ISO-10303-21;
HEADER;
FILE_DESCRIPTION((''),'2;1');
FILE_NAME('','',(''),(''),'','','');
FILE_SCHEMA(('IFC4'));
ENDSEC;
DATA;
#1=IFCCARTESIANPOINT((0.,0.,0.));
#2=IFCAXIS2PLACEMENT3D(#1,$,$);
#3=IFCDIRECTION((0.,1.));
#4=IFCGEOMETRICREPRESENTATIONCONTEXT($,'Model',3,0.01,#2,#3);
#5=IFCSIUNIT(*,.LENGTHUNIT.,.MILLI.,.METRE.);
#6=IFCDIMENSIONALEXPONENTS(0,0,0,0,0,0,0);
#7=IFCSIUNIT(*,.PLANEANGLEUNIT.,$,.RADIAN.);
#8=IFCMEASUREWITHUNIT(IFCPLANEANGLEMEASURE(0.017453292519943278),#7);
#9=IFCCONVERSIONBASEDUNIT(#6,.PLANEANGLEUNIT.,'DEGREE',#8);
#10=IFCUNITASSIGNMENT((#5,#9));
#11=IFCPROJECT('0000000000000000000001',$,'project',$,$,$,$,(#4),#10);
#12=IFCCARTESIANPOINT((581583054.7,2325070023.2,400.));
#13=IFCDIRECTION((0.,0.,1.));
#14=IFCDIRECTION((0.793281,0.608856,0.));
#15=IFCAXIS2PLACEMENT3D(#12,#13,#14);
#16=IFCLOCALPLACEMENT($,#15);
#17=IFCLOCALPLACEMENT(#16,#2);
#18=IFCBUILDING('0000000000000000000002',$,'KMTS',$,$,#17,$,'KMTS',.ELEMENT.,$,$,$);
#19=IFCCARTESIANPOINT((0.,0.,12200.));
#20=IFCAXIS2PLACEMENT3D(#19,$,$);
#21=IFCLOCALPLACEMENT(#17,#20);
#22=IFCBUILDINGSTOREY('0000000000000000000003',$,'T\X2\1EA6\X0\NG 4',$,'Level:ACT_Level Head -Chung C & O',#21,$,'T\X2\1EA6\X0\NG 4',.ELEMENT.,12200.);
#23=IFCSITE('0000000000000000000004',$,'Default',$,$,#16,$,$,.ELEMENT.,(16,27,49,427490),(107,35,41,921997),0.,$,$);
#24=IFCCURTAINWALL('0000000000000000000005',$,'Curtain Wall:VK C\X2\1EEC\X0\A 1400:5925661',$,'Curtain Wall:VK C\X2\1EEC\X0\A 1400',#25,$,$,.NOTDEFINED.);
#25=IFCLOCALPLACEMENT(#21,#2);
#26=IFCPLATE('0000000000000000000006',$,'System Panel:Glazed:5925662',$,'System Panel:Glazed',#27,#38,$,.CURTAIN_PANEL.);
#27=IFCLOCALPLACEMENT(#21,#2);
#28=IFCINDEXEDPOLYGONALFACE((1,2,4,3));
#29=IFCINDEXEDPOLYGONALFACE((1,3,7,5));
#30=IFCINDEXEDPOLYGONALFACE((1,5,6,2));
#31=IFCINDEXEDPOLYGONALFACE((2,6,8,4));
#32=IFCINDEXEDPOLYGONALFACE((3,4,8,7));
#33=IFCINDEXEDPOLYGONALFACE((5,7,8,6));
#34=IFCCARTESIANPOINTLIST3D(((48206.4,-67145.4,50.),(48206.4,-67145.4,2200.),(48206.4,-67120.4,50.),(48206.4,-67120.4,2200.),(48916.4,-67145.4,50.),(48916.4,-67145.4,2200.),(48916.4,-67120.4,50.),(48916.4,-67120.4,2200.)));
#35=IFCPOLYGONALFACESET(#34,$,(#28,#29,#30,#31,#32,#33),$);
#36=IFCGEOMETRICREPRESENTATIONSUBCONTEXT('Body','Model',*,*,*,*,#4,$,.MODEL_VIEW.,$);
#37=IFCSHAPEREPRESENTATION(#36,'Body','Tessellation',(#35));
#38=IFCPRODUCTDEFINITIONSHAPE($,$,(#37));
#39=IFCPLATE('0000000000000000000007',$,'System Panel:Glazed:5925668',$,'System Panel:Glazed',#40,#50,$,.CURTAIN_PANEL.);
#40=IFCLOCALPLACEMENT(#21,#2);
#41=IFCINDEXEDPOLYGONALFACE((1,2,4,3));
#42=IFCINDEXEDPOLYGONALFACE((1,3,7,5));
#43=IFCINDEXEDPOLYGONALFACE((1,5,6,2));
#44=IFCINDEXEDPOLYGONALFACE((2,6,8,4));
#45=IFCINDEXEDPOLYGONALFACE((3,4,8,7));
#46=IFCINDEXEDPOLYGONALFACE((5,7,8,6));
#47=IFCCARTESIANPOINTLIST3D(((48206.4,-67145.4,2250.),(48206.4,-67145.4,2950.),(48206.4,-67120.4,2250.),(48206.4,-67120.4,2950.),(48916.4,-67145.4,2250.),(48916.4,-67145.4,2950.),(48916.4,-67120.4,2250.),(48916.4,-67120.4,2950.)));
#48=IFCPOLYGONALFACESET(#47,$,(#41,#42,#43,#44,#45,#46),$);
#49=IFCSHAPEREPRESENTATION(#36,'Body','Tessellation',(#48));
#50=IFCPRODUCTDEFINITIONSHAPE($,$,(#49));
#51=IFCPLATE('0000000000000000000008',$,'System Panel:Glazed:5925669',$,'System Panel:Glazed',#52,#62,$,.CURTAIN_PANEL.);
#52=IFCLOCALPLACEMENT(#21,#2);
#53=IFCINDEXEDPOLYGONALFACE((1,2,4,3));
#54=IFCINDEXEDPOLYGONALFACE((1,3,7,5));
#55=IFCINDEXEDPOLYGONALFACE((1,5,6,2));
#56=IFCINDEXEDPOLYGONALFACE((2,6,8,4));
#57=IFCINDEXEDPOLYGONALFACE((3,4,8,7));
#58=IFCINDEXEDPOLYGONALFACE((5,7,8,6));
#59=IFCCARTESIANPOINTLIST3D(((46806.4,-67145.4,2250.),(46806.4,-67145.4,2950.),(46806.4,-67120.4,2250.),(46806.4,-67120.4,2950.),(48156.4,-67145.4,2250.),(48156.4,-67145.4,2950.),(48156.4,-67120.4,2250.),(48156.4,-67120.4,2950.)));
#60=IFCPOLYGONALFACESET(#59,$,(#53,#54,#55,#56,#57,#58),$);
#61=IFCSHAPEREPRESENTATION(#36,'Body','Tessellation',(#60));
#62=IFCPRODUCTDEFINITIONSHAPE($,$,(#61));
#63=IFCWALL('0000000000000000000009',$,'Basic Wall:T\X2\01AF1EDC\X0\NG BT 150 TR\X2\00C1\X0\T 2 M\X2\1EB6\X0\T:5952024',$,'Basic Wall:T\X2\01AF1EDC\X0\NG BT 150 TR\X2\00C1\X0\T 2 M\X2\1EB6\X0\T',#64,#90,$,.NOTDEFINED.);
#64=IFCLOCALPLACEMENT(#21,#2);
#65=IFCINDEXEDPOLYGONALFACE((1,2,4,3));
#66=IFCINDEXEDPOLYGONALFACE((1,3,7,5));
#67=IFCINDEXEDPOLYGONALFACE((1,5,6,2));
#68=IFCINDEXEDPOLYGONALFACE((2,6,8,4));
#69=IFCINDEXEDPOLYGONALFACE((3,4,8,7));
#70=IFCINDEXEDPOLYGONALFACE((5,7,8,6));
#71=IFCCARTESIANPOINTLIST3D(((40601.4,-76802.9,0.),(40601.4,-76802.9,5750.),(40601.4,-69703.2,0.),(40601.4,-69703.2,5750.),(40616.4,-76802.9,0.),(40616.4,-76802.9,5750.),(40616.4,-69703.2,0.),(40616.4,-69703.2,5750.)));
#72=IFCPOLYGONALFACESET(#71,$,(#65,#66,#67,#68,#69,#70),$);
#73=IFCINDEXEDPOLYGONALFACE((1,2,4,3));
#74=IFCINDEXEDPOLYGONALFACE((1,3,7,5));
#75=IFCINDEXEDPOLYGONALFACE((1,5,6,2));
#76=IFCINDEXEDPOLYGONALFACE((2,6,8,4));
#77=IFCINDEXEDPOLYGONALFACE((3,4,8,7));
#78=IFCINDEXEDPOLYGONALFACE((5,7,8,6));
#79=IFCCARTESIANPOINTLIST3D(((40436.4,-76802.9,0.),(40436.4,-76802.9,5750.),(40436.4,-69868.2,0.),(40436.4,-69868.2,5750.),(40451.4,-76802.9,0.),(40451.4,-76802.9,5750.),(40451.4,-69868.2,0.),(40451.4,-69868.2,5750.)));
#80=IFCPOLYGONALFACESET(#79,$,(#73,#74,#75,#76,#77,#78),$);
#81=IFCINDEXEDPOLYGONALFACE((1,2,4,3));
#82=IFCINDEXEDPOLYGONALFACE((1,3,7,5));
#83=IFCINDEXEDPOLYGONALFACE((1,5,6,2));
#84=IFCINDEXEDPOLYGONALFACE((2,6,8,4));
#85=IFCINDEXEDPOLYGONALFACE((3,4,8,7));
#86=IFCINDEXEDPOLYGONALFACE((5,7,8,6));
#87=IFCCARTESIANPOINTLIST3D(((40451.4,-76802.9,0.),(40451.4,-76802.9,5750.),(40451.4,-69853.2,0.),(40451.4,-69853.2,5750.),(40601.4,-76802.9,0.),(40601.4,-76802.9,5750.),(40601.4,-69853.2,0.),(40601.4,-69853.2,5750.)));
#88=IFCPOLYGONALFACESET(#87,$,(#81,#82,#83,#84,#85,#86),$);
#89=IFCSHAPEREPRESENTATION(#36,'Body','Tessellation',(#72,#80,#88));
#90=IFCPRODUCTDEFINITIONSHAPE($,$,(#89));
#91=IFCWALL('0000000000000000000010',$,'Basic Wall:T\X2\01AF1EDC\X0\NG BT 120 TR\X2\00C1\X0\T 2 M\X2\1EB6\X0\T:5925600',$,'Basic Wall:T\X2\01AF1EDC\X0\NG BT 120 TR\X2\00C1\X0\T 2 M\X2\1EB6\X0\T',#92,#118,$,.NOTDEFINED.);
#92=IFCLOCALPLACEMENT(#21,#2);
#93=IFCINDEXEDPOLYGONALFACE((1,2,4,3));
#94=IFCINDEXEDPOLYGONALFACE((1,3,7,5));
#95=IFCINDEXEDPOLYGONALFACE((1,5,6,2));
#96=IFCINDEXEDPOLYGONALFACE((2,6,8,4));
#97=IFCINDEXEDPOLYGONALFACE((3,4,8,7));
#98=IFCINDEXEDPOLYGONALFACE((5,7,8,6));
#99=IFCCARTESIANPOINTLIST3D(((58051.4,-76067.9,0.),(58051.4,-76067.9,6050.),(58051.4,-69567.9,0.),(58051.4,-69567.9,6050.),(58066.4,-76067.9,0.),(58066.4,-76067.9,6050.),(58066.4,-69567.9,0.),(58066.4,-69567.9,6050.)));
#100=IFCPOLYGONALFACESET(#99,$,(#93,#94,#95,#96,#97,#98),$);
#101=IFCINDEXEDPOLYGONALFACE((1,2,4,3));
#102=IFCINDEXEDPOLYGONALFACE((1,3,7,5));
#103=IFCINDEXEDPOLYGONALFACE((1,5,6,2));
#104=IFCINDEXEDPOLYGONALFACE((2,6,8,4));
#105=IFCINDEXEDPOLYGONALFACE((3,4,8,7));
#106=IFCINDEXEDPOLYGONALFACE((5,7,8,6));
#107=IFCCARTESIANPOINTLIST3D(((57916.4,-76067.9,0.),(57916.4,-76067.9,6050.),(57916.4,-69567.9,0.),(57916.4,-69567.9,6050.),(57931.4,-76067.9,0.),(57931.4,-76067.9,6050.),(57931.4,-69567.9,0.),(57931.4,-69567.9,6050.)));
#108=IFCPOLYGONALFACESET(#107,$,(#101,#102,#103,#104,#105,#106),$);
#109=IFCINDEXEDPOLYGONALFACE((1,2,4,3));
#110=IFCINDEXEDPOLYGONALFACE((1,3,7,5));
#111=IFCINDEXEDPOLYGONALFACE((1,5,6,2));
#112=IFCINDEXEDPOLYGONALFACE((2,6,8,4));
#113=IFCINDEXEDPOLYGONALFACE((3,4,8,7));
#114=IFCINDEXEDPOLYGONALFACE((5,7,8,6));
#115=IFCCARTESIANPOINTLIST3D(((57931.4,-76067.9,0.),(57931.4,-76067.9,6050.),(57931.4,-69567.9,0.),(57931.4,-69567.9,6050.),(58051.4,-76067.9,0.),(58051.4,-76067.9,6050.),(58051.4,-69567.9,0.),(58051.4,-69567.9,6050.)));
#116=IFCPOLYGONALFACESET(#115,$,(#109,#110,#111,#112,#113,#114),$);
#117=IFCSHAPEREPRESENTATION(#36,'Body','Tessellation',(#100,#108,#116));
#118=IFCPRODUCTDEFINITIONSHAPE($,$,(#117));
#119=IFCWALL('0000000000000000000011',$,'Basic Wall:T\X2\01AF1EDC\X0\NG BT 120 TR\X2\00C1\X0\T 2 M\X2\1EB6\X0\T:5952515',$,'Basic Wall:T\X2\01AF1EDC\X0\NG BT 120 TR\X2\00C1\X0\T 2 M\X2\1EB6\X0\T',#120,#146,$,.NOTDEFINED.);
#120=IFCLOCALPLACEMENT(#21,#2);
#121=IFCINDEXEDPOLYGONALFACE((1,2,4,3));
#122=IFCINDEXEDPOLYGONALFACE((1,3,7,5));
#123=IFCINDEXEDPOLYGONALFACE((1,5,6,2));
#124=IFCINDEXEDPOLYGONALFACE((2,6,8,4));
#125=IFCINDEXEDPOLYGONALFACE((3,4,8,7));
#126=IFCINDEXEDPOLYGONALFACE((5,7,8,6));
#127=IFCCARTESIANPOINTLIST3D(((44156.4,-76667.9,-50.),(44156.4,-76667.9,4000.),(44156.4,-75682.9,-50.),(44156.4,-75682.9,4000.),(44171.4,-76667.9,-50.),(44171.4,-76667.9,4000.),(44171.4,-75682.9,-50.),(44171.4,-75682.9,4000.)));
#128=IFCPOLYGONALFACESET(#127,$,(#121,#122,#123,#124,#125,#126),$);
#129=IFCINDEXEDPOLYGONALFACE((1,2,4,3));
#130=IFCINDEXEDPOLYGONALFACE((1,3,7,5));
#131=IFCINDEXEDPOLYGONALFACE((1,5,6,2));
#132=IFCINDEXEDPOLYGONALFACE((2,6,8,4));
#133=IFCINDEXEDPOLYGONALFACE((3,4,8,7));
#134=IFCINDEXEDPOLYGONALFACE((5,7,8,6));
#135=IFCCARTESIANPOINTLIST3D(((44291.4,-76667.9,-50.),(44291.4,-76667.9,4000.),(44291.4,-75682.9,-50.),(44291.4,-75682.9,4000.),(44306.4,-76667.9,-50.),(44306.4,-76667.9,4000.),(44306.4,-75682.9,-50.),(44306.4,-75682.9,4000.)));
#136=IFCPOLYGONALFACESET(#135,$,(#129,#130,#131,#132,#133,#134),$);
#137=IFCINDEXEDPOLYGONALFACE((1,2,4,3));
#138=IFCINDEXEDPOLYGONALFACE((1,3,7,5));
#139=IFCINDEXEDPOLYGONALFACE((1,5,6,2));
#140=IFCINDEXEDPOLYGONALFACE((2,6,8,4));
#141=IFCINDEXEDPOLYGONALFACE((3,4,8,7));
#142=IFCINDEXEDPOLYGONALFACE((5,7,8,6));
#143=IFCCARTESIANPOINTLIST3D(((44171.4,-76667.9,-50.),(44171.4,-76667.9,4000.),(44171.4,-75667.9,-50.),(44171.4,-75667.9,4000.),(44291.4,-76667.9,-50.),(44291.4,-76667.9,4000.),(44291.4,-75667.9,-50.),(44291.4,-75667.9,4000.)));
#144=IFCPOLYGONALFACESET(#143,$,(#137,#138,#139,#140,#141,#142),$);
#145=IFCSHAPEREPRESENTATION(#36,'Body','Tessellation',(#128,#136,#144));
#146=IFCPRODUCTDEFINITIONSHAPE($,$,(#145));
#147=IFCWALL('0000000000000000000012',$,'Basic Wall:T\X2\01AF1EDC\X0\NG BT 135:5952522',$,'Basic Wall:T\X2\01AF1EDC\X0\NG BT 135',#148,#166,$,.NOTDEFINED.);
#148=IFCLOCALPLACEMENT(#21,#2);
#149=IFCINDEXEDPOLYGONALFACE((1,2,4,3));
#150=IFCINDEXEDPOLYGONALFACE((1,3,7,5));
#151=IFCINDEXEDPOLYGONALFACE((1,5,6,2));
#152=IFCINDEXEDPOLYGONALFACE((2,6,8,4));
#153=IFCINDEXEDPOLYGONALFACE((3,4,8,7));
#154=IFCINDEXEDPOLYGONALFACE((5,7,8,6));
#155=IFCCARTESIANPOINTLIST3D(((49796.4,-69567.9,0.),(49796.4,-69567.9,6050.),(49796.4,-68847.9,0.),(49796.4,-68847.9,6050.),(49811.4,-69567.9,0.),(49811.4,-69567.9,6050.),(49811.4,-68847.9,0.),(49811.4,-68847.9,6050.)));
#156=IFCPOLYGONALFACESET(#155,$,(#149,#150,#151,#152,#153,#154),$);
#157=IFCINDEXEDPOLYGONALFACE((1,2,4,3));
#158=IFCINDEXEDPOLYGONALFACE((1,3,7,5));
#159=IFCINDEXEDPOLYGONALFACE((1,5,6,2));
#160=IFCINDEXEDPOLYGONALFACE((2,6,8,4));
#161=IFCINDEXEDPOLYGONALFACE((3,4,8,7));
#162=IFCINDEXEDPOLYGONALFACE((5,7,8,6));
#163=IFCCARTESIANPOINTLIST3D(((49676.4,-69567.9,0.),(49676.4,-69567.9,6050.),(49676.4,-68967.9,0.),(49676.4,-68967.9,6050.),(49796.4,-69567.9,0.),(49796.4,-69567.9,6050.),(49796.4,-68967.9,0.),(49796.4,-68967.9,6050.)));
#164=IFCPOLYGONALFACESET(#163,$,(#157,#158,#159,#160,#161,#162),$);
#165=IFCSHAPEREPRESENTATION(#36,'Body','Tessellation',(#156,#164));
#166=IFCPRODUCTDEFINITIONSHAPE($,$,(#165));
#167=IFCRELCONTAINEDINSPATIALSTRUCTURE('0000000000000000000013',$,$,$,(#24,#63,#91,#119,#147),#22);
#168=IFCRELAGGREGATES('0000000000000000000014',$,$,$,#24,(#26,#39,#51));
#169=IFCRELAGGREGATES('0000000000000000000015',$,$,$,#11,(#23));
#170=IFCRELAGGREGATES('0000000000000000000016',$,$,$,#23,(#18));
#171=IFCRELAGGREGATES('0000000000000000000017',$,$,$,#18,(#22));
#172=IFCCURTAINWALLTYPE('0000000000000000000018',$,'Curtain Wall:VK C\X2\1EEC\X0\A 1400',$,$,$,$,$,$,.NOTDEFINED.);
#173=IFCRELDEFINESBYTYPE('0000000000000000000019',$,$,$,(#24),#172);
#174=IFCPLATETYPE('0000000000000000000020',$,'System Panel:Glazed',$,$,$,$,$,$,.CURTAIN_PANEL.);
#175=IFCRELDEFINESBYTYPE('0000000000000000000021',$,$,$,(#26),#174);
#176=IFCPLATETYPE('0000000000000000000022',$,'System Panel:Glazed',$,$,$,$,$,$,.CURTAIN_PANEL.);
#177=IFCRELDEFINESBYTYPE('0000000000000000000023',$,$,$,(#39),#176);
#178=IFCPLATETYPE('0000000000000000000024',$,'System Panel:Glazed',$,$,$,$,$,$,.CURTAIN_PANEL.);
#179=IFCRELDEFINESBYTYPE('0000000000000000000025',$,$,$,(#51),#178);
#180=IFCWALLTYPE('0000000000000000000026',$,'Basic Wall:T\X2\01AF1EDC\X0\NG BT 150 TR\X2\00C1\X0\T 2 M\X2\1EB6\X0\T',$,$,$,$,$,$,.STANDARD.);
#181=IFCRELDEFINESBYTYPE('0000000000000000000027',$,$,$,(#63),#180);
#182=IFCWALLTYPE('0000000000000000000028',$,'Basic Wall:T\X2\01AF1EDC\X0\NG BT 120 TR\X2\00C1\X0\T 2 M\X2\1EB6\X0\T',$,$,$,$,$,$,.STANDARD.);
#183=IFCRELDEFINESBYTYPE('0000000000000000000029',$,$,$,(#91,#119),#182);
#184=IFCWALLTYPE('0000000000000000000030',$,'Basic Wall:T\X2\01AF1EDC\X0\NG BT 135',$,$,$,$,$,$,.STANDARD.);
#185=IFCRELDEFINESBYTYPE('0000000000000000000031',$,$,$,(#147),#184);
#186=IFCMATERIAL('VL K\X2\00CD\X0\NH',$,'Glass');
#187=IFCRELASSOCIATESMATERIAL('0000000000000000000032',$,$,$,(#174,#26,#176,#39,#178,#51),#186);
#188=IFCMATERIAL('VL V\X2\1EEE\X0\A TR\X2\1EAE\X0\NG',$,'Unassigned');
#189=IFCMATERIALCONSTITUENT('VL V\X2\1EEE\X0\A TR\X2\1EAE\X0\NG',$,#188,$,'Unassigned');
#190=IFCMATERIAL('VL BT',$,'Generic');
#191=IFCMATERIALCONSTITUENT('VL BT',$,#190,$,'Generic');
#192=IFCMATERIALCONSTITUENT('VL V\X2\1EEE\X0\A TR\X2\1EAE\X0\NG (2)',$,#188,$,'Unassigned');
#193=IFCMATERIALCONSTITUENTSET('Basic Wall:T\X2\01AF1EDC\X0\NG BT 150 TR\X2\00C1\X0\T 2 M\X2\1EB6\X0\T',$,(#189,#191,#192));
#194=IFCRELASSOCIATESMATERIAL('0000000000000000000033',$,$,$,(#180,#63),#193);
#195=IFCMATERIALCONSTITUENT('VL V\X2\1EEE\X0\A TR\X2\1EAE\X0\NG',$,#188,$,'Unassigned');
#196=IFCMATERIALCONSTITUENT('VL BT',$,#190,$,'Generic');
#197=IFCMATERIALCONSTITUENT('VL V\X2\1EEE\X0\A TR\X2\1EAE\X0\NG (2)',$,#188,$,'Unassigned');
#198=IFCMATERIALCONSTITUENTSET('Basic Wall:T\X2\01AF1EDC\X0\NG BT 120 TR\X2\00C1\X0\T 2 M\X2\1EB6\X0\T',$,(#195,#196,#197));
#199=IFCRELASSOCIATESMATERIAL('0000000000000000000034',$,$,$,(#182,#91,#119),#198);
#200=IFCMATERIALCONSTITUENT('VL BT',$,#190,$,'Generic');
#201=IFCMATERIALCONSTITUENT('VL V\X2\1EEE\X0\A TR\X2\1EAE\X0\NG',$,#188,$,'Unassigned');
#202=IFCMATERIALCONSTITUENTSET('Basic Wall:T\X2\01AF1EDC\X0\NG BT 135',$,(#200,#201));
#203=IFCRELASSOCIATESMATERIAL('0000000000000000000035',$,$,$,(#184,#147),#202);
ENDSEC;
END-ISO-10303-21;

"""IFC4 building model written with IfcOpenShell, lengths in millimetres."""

from ifc_helpers import new_model, entity, si_unit, converted_unit, direction, frame, origin, place, context, subcontext, project, spatial, indexed_curve, outline, extrude, source, transform, mapped, material, constituent, constituent_set, type_object, type_shapes, element, aggregate, save


model = new_model("IFC4")

# Units and contexts
model_context = context("Model", 3, precision=0.01, world=origin(), true_north=direction((0.0, 1.0)))
body_context = subcontext(model_context, "Body", "Model", "MODEL_VIEW")
ifc_project = project(units=[si_unit("LENGTHUNIT", "METRE", prefix="MILLI"), converted_unit("PLANEANGLEUNIT", "DEGREE", entity("IfcPlaneAngleMeasure", 0.017453292519943278), si_unit("PLANEANGLEUNIT", "RADIAN"), dimensions=[0, 0, 0, 0, 0, 0, 0])], contexts=[model_context])

# Site, building, storey
site_placement = place(None, frame((581583054.7, 2325070023.2, 400.0), z_axis=(0.0, 0.0, 1.0), x_axis=(0.793281, 0.608856, 0.0)))
site = spatial("IfcSite", under=ifc_project, at=site_placement, Name="Default", CompositionType="ELEMENT", RefLatitude=(16, 27, 49, 427490), RefLongitude=(107, 35, 41, 921997), RefElevation=0.0)
building_placement = place(site_placement, origin())
building = spatial("IfcBuilding", under=site, at=building_placement, Name="KMTS", LongName="KMTS", CompositionType="ELEMENT")
storey_placement = place(building_placement, frame((0.0, 0.0, 12200.0)))
storey = spatial("IfcBuildingStorey", under=building, at=storey_placement, Name="TẦNG 4", ObjectType="Level:ACT_Level Head -Chung C & O", LongName="TẦNG 4", CompositionType="ELEMENT", Elevation=12200.0)

# Curtain wall, plates
curtain_wall_type = type_object("IfcCurtainWallType", Name="Curtain Wall:VK CỬA 1400", PredefinedType="NOTDEFINED")
curtain_wall_placement = place(storey_placement, frame((0.0, 0.0, -12200.0)))
curtain_wall = element("IfcCurtainWall", 1, at=curtain_wall_placement, inside=storey, type_object=curtain_wall_type, Name="Curtain Wall:VK CỬA 1400:5925661", ObjectType="Curtain Wall:VK CỬA 1400", PredefinedType="NOTDEFINED")
ifc_material_1 = material(Name="VL KÍNH", Category="Glass")
plate_type_1 = type_object("IfcPlateType", Name="System Panel:Glazed", PredefinedType="CURTAIN_PANEL", material=ifc_material_1)
shared_shape_1 = source(origin(), body_context, "Body", "SweptSolid", [
    extrude(outline(indexed_curve([(-12.5, -355.0), (12.5, -355.0), (12.5, 355.0), (-12.5, 355.0), (-12.5, -355.0)], self_intersect=False)), frame((0.0, 0.0, 0.0), z_axis=(0.0, 0.0, 1.0), x_axis=(0.0, 1.0, 0.0)), (0.0, 0.0, 1.0), 2150.0),
])
type_shapes(plate_type_1, [shared_shape_1])
plate_1_placement = place(curtain_wall_placement, frame((48561.4, -67132.9, 12250.0), z_axis=(0.0, 0.0, 1.0), x_axis=(-1.0, 0.0, 0.0)))
plate_1 = element("IfcPlate", 2, at=plate_1_placement, type_object=plate_type_1, material=ifc_material_1, Name="System Panel:Glazed:5925662", ObjectType="System Panel:Glazed", PredefinedType="CURTAIN_PANEL", context=body_context, shape_type="MappedRepresentation", body=[
    mapped(shared_shape_1, transform((0.0, 0.0, 0.0), scale=1.0)),
])
plate_type_2 = type_object("IfcPlateType", Name="System Panel:Glazed", PredefinedType="CURTAIN_PANEL", material=ifc_material_1)
shared_shape_2 = source(origin(), body_context, "Body", "SweptSolid", [
    extrude(outline(indexed_curve([(-12.5, -355.0), (12.5, -355.0), (12.5, 355.0), (-12.5, 355.0), (-12.5, -355.0)], self_intersect=False)), frame((0.0, 0.0, 0.0), z_axis=(0.0, 0.0, 1.0), x_axis=(0.0, 1.0, 0.0)), (0.0, 0.0, 1.0), 700.0),
])
type_shapes(plate_type_2, [shared_shape_2])
plate_2_placement = place(curtain_wall_placement, frame((48561.4, -67132.9, 14450.0), z_axis=(0.0, 0.0, 1.0), x_axis=(-1.0, 0.0, 0.0)))
plate_2 = element("IfcPlate", 3, at=plate_2_placement, type_object=plate_type_2, material=ifc_material_1, Name="System Panel:Glazed:5925668", ObjectType="System Panel:Glazed", PredefinedType="CURTAIN_PANEL", context=body_context, shape_type="MappedRepresentation", body=[
    mapped(shared_shape_2, transform((0.0, 0.0, 0.0), scale=1.0)),
])
plate_type_3 = type_object("IfcPlateType", Name="System Panel:Glazed", PredefinedType="CURTAIN_PANEL", material=ifc_material_1)
shared_shape_3 = source(origin(), body_context, "Body", "SweptSolid", [
    extrude(outline(indexed_curve([(-12.5, -675.0), (12.5, -675.0), (12.5, 675.0), (-12.5, 675.0), (-12.5, -675.0)], self_intersect=False)), frame((0.0, 0.0, 0.0), z_axis=(0.0, 0.0, 1.0), x_axis=(0.0, 1.0, 0.0)), (0.0, 0.0, 1.0), 700.0),
])
type_shapes(plate_type_3, [shared_shape_3])
plate_3_placement = place(curtain_wall_placement, frame((47481.4, -67132.9, 14450.0), z_axis=(0.0, 0.0, 1.0), x_axis=(-1.0, 0.0, 0.0)))
plate_3 = element("IfcPlate", 4, at=plate_3_placement, type_object=plate_type_3, material=ifc_material_1, Name="System Panel:Glazed:5925669", ObjectType="System Panel:Glazed", PredefinedType="CURTAIN_PANEL", context=body_context, shape_type="MappedRepresentation", body=[
    mapped(shared_shape_3, transform((0.0, 0.0, 0.0), scale=1.0)),
])

# Wall
ifc_material_2 = material(Name="VL VỮA TRẮNG", Category="Unassigned")
ifc_constituent_1 = constituent(ifc_material_2, Name="VL VỮA TRẮNG", Category="Unassigned")
ifc_material_3 = material(Name="VL BT", Category="Generic")
ifc_constituent_2 = constituent(ifc_material_3, Name="VL BT", Category="Generic")
ifc_constituent_3 = constituent(ifc_material_2, Name="VL VỮA TRẮNG (2)", Category="Unassigned")
ifc_constituent_set_1 = constituent_set(constituents=[ifc_constituent_1, ifc_constituent_2, ifc_constituent_3], Name="Basic Wall:TƯỜNG BT 150 TRÁT 2 MẶT")
wall_type_1 = type_object("IfcWallType", Name="Basic Wall:TƯỜNG BT 150 TRÁT 2 MẶT", PredefinedType="STANDARD", material=ifc_constituent_set_1)
wall_1_placement = place(storey_placement, frame((40526.4, -76802.9, 0.0), z_axis=(0.0, 0.0, 1.0), x_axis=(0.0, 1.0, 0.0)))
element("IfcWall", 5, at=wall_1_placement, inside=storey, type_object=wall_type_1, material=ifc_constituent_set_1, Name="Basic Wall:TƯỜNG BT 150 TRÁT 2 MẶT:5952024", ObjectType="Basic Wall:TƯỜNG BT 150 TRÁT 2 MẶT", PredefinedType="NOTDEFINED", context=body_context, shape_type="SweptSolid", body=[
    extrude(outline(indexed_curve([(-7.5, -3549.9), (7.5, -3549.9), (7.5, 3549.9), (-7.5, 3549.9), (-7.5, -3549.9)], self_intersect=False)), frame((3549.9, -82.5, 0.0), z_axis=(0.0, 0.0, 1.0), x_axis=(0.0, 1.0, 0.0)), (0.0, 0.0, 1.0), 5750.0),
    extrude(outline(indexed_curve([(-7.5, -3467.4), (7.5, -3467.4), (7.5, 3467.4), (-7.5, 3467.4), (-7.5, -3467.4)], self_intersect=False)), frame((3467.4, 82.5, 0.0), z_axis=(0.0, 0.0, 1.0), x_axis=(0.0, -1.0, 0.0)), (0.0, 0.0, 1.0), 5750.0),
    extrude(outline(indexed_curve([(-3474.9, -75.0), (3474.9, -75.0), (3474.9, 75.0), (-3474.9, 75.0), (-3474.9, -75.0)], self_intersect=False)), frame((3474.9, 0.0, 0.0)), (0.0, 0.0, 1.0), 5750.0),
])

# Wall
ifc_constituent_4 = constituent(ifc_material_2, Name="VL VỮA TRẮNG", Category="Unassigned")
ifc_constituent_5 = constituent(ifc_material_3, Name="VL BT", Category="Generic")
ifc_constituent_6 = constituent(ifc_material_2, Name="VL VỮA TRẮNG (2)", Category="Unassigned")
ifc_constituent_set_2 = constituent_set(constituents=[ifc_constituent_4, ifc_constituent_5, ifc_constituent_6], Name="Basic Wall:TƯỜNG BT 120 TRÁT 2 MẶT")
wall_type_2 = type_object("IfcWallType", Name="Basic Wall:TƯỜNG BT 120 TRÁT 2 MẶT", PredefinedType="STANDARD", material=ifc_constituent_set_2)
wall_2_placement = place(storey_placement, frame((57991.4, -76067.9, 0.0), z_axis=(0.0, 0.0, 1.0), x_axis=(0.0, 1.0, 0.0)))
element("IfcWall", 6, at=wall_2_placement, inside=storey, type_object=wall_type_2, material=ifc_constituent_set_2, Name="Basic Wall:TƯỜNG BT 120 TRÁT 2 MẶT:5925600", ObjectType="Basic Wall:TƯỜNG BT 120 TRÁT 2 MẶT", PredefinedType="NOTDEFINED", context=body_context, shape_type="SweptSolid", body=[
    extrude(outline(indexed_curve([(-7.5, -3250.0), (7.5, -3250.0), (7.5, 3250.0), (-7.5, 3250.0), (-7.5, -3250.0)], self_intersect=False)), frame((3250.0, -67.5, 0.0), z_axis=(0.0, 0.0, 1.0), x_axis=(0.0, 1.0, 0.0)), (0.0, 0.0, 1.0), 6050.0),
    extrude(outline(indexed_curve([(-7.5, -3250.0), (7.5, -3250.0), (7.5, 3250.0), (-7.5, 3250.0), (-7.5, -3250.0)], self_intersect=False)), frame((3250.0, 67.5, 0.0), z_axis=(0.0, 0.0, 1.0), x_axis=(0.0, -1.0, 0.0)), (0.0, 0.0, 1.0), 6050.0),
    extrude(outline(indexed_curve([(-3250.0, -60.0), (3250.0, -60.0), (3250.0, 60.0), (-3250.0, 60.0), (-3250.0, -60.0)], self_intersect=False)), frame((3250.0, 0.0, 0.0)), (0.0, 0.0, 1.0), 6050.0),
])

# Wall
wall_3_placement = place(storey_placement, frame((44231.4, -75682.9, -50.0), z_axis=(0.0, 0.0, 1.0), x_axis=(0.0, -1.0, 0.0)))
element("IfcWall", 7, at=wall_3_placement, inside=storey, type_object=wall_type_2, material=ifc_constituent_set_2, Name="Basic Wall:TƯỜNG BT 120 TRÁT 2 MẶT:5952515", ObjectType="Basic Wall:TƯỜNG BT 120 TRÁT 2 MẶT", PredefinedType="NOTDEFINED", context=body_context, shape_type="SweptSolid", body=[
    extrude(outline(indexed_curve([(-7.5, -492.5), (7.5, -492.5), (7.5, 492.5), (-7.5, 492.5), (-7.5, -492.5)], self_intersect=False)), frame((492.5, -67.5, 0.0), z_axis=(0.0, 0.0, 1.0), x_axis=(0.0, 1.0, 0.0)), (0.0, 0.0, 1.0), 4050.0),
    extrude(outline(indexed_curve([(-7.5, -492.5), (7.5, -492.5), (7.5, 492.5), (-7.5, 492.5), (-7.5, -492.5)], self_intersect=False)), frame((492.5, 67.5, 0.0), z_axis=(0.0, 0.0, 1.0), x_axis=(0.0, -1.0, 0.0)), (0.0, 0.0, 1.0), 4050.0),
    extrude(outline(indexed_curve([(-500.0, -60.0), (500.0, -60.0), (500.0, 60.0), (-500.0, 60.0), (-500.0, -60.0)], self_intersect=False)), frame((485.0, 0.0, 0.0)), (0.0, 0.0, 1.0), 4050.0),
])

# Wall
ifc_constituent_7 = constituent(ifc_material_3, Name="VL BT", Category="Generic")
ifc_constituent_8 = constituent(ifc_material_2, Name="VL VỮA TRẮNG", Category="Unassigned")
ifc_constituent_set_3 = constituent_set(constituents=[ifc_constituent_7, ifc_constituent_8], Name="Basic Wall:TƯỜNG BT 135")
wall_type_3 = type_object("IfcWallType", Name="Basic Wall:TƯỜNG BT 135", PredefinedType="STANDARD", material=ifc_constituent_set_3)
wall_4_placement = place(storey_placement, frame((49743.9, -68967.9, 0.0), z_axis=(0.0, 0.0, 1.0), x_axis=(0.0, -1.0, 0.0)))
element("IfcWall", 8, at=wall_4_placement, inside=storey, type_object=wall_type_3, material=ifc_constituent_set_3, Name="Basic Wall:TƯỜNG BT 135:5952522", ObjectType="Basic Wall:TƯỜNG BT 135", PredefinedType="NOTDEFINED", context=body_context, shape_type="SweptSolid", body=[
    extrude(outline(indexed_curve([(-7.5, -360.0), (7.5, -360.0), (7.5, 360.0), (-7.5, 360.0), (-7.5, -360.0)], self_intersect=False)), frame((240.0, 60.0, 0.0), z_axis=(0.0, 0.0, 1.0), x_axis=(0.0, -1.0, 0.0)), (0.0, 0.0, 1.0), 6050.0),
    extrude(outline(indexed_curve([(-60.0, -300.0), (60.0, -300.0), (60.0, 300.0), (-60.0, 300.0), (-60.0, -300.0)], self_intersect=False)), frame((300.0, -7.5, 0.0), z_axis=(0.0, 0.0, 1.0), x_axis=(0.0, 1.0, 0.0)), (0.0, 0.0, 1.0), 6050.0),
])

aggregate(curtain_wall, [plate_1, plate_2, plate_3])

save(model, "model.ifc")
